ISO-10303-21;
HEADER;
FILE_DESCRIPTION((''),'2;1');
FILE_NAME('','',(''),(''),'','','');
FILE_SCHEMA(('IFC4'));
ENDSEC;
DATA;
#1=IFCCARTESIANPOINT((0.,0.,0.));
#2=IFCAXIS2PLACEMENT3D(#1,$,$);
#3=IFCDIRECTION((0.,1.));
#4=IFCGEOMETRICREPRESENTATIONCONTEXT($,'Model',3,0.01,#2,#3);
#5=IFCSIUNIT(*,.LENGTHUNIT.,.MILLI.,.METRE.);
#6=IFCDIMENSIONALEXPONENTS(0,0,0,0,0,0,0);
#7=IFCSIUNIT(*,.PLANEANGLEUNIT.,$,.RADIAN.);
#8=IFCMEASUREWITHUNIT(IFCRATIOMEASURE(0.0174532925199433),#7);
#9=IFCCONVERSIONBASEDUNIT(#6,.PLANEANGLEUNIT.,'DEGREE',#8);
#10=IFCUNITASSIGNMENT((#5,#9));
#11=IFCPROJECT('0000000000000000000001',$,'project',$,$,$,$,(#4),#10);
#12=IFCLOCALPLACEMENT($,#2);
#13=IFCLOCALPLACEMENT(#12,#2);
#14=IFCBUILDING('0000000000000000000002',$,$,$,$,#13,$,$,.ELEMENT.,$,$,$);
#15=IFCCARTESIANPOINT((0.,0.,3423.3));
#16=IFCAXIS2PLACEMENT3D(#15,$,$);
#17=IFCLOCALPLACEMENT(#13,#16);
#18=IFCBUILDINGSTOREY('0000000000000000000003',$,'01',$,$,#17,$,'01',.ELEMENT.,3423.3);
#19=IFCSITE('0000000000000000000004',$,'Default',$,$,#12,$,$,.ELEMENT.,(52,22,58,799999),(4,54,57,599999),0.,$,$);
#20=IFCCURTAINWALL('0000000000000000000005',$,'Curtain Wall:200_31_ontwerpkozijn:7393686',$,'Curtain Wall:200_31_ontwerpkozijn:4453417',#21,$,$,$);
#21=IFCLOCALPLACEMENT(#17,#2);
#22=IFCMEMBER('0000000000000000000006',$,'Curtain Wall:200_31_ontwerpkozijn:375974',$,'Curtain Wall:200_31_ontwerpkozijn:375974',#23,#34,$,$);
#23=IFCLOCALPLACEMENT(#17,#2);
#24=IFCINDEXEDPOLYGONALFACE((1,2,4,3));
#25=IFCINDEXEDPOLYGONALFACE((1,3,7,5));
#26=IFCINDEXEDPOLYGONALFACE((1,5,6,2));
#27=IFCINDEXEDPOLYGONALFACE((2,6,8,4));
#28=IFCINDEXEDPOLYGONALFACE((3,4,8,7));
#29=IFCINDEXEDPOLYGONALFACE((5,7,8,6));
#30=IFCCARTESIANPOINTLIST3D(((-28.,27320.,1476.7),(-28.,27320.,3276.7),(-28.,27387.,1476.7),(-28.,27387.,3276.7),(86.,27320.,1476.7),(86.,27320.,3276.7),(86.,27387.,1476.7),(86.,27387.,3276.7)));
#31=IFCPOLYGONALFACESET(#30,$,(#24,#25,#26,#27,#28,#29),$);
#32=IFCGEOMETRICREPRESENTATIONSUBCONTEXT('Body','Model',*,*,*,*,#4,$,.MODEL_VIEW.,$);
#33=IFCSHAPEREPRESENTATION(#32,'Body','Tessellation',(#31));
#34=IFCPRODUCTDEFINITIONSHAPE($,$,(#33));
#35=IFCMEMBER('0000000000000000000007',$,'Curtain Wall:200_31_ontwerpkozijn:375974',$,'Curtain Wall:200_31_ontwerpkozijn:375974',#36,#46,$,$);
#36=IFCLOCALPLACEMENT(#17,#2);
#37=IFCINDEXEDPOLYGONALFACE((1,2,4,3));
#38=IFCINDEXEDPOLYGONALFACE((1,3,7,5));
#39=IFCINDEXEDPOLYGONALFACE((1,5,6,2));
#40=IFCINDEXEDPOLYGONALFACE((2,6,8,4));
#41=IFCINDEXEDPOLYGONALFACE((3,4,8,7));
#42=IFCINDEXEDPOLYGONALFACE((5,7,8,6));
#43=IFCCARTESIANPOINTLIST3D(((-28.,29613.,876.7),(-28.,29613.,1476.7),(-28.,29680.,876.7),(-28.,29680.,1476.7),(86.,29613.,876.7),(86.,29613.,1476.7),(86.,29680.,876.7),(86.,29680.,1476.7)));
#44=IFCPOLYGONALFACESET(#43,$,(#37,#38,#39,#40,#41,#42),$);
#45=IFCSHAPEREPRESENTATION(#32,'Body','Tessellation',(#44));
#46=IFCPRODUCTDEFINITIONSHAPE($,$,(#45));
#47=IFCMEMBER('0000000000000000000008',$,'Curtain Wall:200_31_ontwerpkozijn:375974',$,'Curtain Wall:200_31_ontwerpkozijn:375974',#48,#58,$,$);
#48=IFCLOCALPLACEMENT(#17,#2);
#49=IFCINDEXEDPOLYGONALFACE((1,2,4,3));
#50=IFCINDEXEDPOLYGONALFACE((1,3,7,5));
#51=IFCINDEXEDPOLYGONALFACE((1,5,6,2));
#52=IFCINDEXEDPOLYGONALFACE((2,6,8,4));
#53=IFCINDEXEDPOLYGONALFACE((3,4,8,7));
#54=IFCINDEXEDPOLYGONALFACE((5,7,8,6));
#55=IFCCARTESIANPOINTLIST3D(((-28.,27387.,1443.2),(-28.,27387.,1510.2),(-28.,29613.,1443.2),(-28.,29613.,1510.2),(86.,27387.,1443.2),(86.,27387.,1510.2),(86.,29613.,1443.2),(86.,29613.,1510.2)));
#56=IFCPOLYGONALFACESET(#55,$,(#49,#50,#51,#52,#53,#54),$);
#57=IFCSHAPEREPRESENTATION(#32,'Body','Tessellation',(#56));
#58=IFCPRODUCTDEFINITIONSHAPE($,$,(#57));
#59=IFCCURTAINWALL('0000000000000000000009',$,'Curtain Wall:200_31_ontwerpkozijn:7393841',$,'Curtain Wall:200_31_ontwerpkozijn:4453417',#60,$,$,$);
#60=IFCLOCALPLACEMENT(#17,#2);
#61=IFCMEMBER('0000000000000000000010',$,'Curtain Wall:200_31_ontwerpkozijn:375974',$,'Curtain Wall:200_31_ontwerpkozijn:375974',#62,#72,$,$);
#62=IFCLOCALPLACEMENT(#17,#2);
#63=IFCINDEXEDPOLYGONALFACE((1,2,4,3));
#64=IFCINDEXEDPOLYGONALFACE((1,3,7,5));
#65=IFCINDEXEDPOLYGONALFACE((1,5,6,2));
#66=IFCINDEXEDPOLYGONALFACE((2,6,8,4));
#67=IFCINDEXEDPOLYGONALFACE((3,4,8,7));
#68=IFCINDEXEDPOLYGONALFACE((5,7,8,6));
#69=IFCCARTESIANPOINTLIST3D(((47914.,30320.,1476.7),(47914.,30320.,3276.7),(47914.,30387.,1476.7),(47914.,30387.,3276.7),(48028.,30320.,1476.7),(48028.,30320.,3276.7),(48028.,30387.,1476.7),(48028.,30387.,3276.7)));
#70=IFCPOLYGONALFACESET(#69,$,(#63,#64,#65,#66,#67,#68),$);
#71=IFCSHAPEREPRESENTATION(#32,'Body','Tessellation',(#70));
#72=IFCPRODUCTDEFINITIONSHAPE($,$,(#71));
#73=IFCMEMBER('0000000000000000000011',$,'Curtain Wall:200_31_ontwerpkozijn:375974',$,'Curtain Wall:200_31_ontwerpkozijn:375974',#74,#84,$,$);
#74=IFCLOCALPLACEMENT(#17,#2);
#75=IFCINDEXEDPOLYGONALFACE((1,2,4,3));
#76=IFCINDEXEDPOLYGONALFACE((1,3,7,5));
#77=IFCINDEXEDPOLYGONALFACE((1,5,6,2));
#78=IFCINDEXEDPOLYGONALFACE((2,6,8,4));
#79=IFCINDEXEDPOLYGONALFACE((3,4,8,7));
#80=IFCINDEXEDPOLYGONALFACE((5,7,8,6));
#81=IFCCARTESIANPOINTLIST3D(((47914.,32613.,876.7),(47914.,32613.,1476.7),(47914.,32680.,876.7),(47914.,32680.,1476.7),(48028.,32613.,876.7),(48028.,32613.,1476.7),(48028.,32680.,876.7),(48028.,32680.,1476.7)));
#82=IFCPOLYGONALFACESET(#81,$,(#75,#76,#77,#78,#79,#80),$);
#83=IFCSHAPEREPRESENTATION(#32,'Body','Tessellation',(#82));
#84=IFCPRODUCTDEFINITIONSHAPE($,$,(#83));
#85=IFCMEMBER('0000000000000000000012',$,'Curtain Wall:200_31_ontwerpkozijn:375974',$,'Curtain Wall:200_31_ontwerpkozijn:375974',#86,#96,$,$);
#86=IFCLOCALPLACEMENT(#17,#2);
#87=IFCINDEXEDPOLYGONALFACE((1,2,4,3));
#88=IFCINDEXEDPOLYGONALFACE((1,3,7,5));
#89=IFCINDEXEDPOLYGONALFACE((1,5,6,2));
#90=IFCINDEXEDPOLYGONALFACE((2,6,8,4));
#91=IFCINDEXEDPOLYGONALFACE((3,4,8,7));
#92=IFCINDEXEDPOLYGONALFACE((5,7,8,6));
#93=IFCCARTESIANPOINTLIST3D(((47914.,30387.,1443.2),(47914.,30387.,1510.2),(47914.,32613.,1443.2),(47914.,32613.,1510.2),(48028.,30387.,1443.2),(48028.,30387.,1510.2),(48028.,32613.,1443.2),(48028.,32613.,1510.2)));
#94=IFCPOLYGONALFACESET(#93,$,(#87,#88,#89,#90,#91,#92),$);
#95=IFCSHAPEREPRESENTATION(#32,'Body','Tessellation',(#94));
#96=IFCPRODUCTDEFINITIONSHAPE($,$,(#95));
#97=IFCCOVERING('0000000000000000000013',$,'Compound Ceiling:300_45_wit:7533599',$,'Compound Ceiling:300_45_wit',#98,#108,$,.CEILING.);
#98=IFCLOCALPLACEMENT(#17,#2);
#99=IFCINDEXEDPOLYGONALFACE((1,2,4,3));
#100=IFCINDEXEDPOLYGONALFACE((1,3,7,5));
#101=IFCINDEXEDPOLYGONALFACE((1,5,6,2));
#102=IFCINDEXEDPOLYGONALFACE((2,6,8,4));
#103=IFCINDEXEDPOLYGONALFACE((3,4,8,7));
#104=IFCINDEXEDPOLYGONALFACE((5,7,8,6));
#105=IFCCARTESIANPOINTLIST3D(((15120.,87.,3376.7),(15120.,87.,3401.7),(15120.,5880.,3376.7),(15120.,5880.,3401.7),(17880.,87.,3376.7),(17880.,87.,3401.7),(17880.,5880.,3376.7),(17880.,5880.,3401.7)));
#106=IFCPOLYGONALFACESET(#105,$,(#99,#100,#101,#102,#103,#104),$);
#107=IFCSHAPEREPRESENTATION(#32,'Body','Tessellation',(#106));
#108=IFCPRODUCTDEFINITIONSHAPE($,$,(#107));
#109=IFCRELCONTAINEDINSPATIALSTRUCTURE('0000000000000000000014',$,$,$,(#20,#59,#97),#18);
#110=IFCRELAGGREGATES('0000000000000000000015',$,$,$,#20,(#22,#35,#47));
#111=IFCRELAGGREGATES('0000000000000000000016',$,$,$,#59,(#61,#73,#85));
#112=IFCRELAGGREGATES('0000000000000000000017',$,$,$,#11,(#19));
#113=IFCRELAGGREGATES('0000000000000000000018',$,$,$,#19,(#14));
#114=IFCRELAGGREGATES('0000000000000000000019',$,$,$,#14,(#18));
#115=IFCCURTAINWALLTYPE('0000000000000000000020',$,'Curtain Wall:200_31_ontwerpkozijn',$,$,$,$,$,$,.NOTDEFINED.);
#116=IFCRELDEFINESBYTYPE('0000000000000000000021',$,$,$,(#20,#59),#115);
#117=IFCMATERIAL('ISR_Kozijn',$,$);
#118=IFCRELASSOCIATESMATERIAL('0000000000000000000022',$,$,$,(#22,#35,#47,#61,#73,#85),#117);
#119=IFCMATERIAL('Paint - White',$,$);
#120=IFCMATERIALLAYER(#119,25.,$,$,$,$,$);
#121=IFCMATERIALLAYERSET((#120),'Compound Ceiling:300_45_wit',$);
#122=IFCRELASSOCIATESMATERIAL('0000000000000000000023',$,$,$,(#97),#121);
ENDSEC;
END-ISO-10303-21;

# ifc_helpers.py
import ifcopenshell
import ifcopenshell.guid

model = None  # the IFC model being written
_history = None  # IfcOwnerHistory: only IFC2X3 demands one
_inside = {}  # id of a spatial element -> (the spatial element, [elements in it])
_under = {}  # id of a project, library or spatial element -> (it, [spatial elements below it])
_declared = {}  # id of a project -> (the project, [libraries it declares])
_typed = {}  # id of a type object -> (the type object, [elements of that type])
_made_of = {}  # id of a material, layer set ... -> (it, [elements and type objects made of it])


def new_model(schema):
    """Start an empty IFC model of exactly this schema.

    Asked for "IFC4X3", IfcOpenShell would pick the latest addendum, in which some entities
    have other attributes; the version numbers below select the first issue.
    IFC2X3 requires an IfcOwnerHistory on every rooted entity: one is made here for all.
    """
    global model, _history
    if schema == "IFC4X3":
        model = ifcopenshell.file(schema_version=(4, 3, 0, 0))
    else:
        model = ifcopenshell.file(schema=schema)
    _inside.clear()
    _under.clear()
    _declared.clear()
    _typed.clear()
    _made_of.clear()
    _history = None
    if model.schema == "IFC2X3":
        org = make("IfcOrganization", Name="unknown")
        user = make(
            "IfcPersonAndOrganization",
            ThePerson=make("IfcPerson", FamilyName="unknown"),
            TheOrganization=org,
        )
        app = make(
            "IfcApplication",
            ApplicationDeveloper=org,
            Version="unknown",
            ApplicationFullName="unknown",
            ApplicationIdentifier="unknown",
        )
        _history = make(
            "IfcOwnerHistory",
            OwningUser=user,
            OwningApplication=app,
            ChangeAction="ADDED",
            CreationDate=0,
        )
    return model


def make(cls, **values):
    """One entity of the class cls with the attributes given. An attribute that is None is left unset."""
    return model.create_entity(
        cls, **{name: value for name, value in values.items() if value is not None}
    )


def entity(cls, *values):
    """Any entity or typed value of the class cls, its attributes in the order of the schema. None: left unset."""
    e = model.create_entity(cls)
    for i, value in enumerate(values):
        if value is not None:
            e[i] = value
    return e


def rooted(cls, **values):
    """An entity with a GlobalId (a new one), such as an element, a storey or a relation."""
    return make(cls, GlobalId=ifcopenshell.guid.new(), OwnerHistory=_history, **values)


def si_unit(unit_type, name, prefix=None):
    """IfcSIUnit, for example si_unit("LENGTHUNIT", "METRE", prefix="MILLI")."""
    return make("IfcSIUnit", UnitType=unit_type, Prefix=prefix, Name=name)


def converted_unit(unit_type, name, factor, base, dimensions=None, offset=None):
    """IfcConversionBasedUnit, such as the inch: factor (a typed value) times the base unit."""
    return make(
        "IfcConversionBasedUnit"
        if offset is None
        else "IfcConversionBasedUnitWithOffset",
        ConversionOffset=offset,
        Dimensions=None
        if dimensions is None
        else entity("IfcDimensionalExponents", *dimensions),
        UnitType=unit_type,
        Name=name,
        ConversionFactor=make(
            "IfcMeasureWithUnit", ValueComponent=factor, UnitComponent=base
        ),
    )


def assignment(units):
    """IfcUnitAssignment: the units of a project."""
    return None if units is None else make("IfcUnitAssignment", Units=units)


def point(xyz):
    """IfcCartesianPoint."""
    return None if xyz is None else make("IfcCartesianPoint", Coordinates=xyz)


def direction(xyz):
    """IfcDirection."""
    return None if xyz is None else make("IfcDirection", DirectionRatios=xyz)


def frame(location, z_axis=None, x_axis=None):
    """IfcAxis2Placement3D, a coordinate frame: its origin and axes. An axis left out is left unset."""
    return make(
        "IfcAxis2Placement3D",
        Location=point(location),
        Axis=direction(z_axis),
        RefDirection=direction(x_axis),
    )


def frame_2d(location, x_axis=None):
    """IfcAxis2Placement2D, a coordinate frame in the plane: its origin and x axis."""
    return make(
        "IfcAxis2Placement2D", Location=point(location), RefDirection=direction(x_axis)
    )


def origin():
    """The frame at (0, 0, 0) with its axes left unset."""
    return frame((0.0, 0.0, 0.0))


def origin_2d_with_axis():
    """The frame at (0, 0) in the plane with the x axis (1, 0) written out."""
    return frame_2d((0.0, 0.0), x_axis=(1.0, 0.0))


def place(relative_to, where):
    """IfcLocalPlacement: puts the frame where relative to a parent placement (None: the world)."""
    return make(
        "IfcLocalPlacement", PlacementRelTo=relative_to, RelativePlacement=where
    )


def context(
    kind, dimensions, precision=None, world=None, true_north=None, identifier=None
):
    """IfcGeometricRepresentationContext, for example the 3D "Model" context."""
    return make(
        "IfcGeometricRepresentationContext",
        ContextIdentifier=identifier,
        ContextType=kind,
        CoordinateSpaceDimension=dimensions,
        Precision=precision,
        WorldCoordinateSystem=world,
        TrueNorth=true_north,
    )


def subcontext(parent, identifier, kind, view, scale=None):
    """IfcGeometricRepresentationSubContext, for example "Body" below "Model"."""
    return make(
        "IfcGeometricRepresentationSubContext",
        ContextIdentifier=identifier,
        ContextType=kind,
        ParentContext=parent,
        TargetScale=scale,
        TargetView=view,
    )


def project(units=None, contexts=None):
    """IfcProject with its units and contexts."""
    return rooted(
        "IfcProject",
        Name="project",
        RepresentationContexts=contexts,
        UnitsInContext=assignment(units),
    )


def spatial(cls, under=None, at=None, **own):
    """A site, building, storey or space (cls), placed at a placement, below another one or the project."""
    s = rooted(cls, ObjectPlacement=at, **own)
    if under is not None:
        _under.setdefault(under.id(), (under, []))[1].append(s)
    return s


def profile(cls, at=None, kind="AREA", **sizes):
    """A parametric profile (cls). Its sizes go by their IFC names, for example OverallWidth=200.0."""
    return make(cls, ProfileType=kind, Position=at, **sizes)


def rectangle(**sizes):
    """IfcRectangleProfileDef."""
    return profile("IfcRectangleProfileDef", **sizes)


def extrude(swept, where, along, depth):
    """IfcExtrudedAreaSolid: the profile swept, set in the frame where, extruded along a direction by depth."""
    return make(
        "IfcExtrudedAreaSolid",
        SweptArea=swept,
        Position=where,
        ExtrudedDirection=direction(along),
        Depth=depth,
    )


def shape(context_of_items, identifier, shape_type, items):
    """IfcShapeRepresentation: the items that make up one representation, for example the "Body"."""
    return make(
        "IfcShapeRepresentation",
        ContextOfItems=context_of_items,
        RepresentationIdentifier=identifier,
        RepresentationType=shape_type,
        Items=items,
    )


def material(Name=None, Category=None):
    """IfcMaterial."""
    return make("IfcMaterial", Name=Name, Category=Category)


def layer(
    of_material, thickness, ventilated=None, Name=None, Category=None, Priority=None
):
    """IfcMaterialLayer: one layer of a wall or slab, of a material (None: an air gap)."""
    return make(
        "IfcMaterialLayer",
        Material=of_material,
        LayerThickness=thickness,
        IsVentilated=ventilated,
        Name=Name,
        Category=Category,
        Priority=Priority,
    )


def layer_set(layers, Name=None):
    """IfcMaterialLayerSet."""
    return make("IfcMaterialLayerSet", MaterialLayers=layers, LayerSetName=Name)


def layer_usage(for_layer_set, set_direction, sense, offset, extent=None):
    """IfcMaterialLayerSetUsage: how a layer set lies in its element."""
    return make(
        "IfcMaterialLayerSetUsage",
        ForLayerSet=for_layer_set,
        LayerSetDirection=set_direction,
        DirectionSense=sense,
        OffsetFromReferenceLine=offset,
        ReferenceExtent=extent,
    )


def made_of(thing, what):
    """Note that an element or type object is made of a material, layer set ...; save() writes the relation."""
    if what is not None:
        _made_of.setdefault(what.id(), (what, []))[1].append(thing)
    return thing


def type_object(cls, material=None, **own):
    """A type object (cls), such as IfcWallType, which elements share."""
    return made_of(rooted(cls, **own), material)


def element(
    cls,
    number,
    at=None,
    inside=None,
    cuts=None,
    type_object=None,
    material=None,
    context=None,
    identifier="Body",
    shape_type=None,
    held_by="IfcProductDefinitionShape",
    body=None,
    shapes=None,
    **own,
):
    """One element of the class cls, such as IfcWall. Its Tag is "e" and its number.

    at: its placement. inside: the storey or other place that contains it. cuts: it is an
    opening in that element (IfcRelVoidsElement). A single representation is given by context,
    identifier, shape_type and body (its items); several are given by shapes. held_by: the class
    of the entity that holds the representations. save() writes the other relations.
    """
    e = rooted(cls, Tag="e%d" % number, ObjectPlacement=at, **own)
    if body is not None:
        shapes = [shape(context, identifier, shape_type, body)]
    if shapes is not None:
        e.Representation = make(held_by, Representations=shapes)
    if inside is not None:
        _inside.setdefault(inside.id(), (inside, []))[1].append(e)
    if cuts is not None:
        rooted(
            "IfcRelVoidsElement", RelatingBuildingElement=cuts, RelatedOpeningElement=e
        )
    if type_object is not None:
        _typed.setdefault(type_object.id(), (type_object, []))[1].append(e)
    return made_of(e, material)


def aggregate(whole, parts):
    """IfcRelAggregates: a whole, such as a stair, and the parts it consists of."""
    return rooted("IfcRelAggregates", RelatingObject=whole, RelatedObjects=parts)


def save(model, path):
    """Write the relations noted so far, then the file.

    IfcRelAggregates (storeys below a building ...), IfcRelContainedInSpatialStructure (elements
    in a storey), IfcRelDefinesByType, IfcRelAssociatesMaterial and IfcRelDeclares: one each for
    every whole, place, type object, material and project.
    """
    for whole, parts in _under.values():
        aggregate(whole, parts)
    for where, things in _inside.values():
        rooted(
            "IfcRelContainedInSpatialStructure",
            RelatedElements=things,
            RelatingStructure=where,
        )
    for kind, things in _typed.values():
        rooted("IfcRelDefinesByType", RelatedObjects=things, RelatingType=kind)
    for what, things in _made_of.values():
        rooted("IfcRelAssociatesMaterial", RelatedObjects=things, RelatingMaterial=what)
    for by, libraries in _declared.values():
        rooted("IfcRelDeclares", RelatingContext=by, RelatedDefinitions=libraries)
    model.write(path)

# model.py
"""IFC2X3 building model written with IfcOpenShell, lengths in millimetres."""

from ifc_helpers import new_model, entity, si_unit, converted_unit, direction, frame, frame_2d, origin, origin_2d_with_axis, place, context, subcontext, project, spatial, rectangle, extrude, material, layer, layer_set, layer_usage, type_object, element, aggregate, save


model = new_model("IFC2X3")

# Units and contexts
model_context = context("Model", 3, precision=0.01, world=origin(), true_north=direction((0.0, 1.0)))
body_context = subcontext(model_context, "Body", "Model", "MODEL_VIEW")
ifc_project = project(units=[si_unit("LENGTHUNIT", "METRE", prefix="MILLI"), converted_unit("PLANEANGLEUNIT", "DEGREE", entity("IfcRatioMeasure", 0.0174532925199433), si_unit("PLANEANGLEUNIT", "RADIAN"), dimensions=[0, 0, 0, 0, 0, 0, 0])], contexts=[model_context])

# Site, building, storey
site_placement = place(None, origin())
site = spatial("IfcSite", under=ifc_project, at=site_placement, Name="Default", CompositionType="ELEMENT", RefLatitude=(52, 22, 58, 799999), RefLongitude=(4, 54, 57, 599999), RefElevation=0.0)
building_placement = place(site_placement, origin())
building = spatial("IfcBuilding", under=site, at=building_placement, CompositionType="ELEMENT")
storey_placement = place(building_placement, frame((0.0, 0.0, 3423.3)))
storey = spatial("IfcBuildingStorey", under=building, at=storey_placement, Name="01", LongName="01", CompositionType="ELEMENT", Elevation=3423.3)

# Curtain walls, members
curtain_wall_type = type_object("IfcCurtainWallType", Name="Curtain Wall:200_31_ontwerpkozijn", PredefinedType="NOTDEFINED")
curtain_wall_1_placement = place(storey_placement, frame((0.0, 0.0, -3423.3)))
curtain_wall_1 = element("IfcCurtainWall", 1, at=curtain_wall_1_placement, inside=storey, type_object=curtain_wall_type, Name="Curtain Wall:200_31_ontwerpkozijn:7393686", ObjectType="Curtain Wall:200_31_ontwerpkozijn:4453417")
ifc_material_1 = material(Name="ISR_Kozijn")
member_1_placement = place(curtain_wall_1_placement, frame((0.0, 0.0, 3423.3)))
member_1 = element("IfcMember", 2, at=member_1_placement, material=ifc_material_1, Name="Curtain Wall:200_31_ontwerpkozijn:375974", ObjectType="Curtain Wall:200_31_ontwerpkozijn:375974", context=body_context, shape_type="SweptSolid", body=[
    extrude(rectangle(XDim=114.0, YDim=67.0, at=origin_2d_with_axis()), frame((29.0, 27353.5, 1476.7), z_axis=(0.0, 0.0, 1.0), x_axis=(-1.0, 0.0, 0.0)), (0.0, 0.0, 1.0), 1800.0),
])
member_2_placement = place(curtain_wall_1_placement, frame((0.0, 0.0, 3423.3)))
member_2 = element("IfcMember", 3, at=member_2_placement, material=ifc_material_1, Name="Curtain Wall:200_31_ontwerpkozijn:375974", ObjectType="Curtain Wall:200_31_ontwerpkozijn:375974", context=body_context, shape_type="SweptSolid", body=[
    extrude(rectangle(XDim=114.0, YDim=67.0, at=origin_2d_with_axis()), frame((29.0, 29646.5, 1476.7), z_axis=(0.0, 0.0, -1.0), x_axis=(-1.0, 0.0, 0.0)), (0.0, 0.0, 1.0), 600.0),
])
member_3_placement = place(curtain_wall_1_placement, frame((0.0, 0.0, 3423.3)))
member_3 = element("IfcMember", 4, at=member_3_placement, material=ifc_material_1, Name="Curtain Wall:200_31_ontwerpkozijn:375974", ObjectType="Curtain Wall:200_31_ontwerpkozijn:375974", context=body_context, shape_type="SweptSolid", body=[
    extrude(rectangle(XDim=67.0, YDim=114.0, at=origin_2d_with_axis()), frame((29.0, 27387.0, 1476.7), z_axis=(0.0, 1.0, 0.0), x_axis=(0.0, 0.0, -1.0)), (0.0, 0.0, 1.0), 2226.0),
])
aggregate(curtain_wall_1, [member_1, member_2, member_3])
curtain_wall_2_placement = place(storey_placement, frame((0.0, 0.0, -3423.3)))
curtain_wall_2 = element("IfcCurtainWall", 5, at=curtain_wall_2_placement, inside=storey, type_object=curtain_wall_type, Name="Curtain Wall:200_31_ontwerpkozijn:7393841", ObjectType="Curtain Wall:200_31_ontwerpkozijn:4453417")
member_4_placement = place(curtain_wall_2_placement, frame((0.0, 0.0, 3423.3)))
member_4 = element("IfcMember", 6, at=member_4_placement, material=ifc_material_1, Name="Curtain Wall:200_31_ontwerpkozijn:375974", ObjectType="Curtain Wall:200_31_ontwerpkozijn:375974", context=body_context, shape_type="SweptSolid", body=[
    extrude(rectangle(XDim=114.0, YDim=67.0, at=frame_2d((0.0, 0.0), x_axis=(1.0, 0.0))), frame((47971.0, 30353.5, 1476.7), z_axis=(0.0, 0.0, 1.0), x_axis=(-1.0, 0.0, 0.0)), (0.0, 0.0, 1.0), 1800.0),
])
member_5_placement = place(curtain_wall_2_placement, frame((0.0, 0.0, 3423.3)))
member_5 = element("IfcMember", 7, at=member_5_placement, material=ifc_material_1, Name="Curtain Wall:200_31_ontwerpkozijn:375974", ObjectType="Curtain Wall:200_31_ontwerpkozijn:375974", context=body_context, shape_type="SweptSolid", body=[
    extrude(rectangle(XDim=114.0, YDim=67.0, at=frame_2d((0.0, 0.0), x_axis=(1.0, 0.0))), frame((47971.0, 32646.5, 1476.7), z_axis=(0.0, 0.0, -1.0), x_axis=(-1.0, 0.0, 0.0)), (0.0, 0.0, 1.0), 600.0),
])
member_6_placement = place(curtain_wall_2_placement, frame((0.0, 0.0, 3423.3)))
member_6 = element("IfcMember", 8, at=member_6_placement, material=ifc_material_1, Name="Curtain Wall:200_31_ontwerpkozijn:375974", ObjectType="Curtain Wall:200_31_ontwerpkozijn:375974", context=body_context, shape_type="SweptSolid", body=[
    extrude(rectangle(XDim=67.0, YDim=114.0, at=frame_2d((0.0, 0.0), x_axis=(1.0, 0.0))), frame((47971.0, 30387.0, 1476.7), z_axis=(0.0, 1.0, 0.0), x_axis=(0.0, 0.0, -1.0)), (0.0, 0.0, 1.0), 2226.0),
])
aggregate(curtain_wall_2, [member_4, member_5, member_6])

# Covering
ifc_material_2 = material(Name="Paint - White")
ifc_layer = layer(ifc_material_2, 25.0)
ifc_layer_set = layer_set([ifc_layer], Name="Compound Ceiling:300_45_wit")
ifc_layer_usage = layer_usage(ifc_layer_set, "AXIS3", "NEGATIVE", 0.0)
covering_placement = place(storey_placement, origin())
element("IfcCovering", 9, at=covering_placement, inside=storey, material=ifc_layer_usage, Name="Compound Ceiling:300_45_wit:7533599", ObjectType="Compound Ceiling:300_45_wit", PredefinedType="CEILING", context=body_context, shape_type="SweptSolid", body=[
    extrude(rectangle(XDim=2760.0, YDim=5793.0, at=frame_2d((0.0, 0.0), x_axis=(1.0, 0.0))), frame((16500.0, 2983.5, 3376.7), z_axis=(0.0, 0.0, 1.0), x_axis=(-1.0, 0.0, 0.0)), (0.0, 0.0, 1.0), 25.0),
])

save(model, "model.ifc")
